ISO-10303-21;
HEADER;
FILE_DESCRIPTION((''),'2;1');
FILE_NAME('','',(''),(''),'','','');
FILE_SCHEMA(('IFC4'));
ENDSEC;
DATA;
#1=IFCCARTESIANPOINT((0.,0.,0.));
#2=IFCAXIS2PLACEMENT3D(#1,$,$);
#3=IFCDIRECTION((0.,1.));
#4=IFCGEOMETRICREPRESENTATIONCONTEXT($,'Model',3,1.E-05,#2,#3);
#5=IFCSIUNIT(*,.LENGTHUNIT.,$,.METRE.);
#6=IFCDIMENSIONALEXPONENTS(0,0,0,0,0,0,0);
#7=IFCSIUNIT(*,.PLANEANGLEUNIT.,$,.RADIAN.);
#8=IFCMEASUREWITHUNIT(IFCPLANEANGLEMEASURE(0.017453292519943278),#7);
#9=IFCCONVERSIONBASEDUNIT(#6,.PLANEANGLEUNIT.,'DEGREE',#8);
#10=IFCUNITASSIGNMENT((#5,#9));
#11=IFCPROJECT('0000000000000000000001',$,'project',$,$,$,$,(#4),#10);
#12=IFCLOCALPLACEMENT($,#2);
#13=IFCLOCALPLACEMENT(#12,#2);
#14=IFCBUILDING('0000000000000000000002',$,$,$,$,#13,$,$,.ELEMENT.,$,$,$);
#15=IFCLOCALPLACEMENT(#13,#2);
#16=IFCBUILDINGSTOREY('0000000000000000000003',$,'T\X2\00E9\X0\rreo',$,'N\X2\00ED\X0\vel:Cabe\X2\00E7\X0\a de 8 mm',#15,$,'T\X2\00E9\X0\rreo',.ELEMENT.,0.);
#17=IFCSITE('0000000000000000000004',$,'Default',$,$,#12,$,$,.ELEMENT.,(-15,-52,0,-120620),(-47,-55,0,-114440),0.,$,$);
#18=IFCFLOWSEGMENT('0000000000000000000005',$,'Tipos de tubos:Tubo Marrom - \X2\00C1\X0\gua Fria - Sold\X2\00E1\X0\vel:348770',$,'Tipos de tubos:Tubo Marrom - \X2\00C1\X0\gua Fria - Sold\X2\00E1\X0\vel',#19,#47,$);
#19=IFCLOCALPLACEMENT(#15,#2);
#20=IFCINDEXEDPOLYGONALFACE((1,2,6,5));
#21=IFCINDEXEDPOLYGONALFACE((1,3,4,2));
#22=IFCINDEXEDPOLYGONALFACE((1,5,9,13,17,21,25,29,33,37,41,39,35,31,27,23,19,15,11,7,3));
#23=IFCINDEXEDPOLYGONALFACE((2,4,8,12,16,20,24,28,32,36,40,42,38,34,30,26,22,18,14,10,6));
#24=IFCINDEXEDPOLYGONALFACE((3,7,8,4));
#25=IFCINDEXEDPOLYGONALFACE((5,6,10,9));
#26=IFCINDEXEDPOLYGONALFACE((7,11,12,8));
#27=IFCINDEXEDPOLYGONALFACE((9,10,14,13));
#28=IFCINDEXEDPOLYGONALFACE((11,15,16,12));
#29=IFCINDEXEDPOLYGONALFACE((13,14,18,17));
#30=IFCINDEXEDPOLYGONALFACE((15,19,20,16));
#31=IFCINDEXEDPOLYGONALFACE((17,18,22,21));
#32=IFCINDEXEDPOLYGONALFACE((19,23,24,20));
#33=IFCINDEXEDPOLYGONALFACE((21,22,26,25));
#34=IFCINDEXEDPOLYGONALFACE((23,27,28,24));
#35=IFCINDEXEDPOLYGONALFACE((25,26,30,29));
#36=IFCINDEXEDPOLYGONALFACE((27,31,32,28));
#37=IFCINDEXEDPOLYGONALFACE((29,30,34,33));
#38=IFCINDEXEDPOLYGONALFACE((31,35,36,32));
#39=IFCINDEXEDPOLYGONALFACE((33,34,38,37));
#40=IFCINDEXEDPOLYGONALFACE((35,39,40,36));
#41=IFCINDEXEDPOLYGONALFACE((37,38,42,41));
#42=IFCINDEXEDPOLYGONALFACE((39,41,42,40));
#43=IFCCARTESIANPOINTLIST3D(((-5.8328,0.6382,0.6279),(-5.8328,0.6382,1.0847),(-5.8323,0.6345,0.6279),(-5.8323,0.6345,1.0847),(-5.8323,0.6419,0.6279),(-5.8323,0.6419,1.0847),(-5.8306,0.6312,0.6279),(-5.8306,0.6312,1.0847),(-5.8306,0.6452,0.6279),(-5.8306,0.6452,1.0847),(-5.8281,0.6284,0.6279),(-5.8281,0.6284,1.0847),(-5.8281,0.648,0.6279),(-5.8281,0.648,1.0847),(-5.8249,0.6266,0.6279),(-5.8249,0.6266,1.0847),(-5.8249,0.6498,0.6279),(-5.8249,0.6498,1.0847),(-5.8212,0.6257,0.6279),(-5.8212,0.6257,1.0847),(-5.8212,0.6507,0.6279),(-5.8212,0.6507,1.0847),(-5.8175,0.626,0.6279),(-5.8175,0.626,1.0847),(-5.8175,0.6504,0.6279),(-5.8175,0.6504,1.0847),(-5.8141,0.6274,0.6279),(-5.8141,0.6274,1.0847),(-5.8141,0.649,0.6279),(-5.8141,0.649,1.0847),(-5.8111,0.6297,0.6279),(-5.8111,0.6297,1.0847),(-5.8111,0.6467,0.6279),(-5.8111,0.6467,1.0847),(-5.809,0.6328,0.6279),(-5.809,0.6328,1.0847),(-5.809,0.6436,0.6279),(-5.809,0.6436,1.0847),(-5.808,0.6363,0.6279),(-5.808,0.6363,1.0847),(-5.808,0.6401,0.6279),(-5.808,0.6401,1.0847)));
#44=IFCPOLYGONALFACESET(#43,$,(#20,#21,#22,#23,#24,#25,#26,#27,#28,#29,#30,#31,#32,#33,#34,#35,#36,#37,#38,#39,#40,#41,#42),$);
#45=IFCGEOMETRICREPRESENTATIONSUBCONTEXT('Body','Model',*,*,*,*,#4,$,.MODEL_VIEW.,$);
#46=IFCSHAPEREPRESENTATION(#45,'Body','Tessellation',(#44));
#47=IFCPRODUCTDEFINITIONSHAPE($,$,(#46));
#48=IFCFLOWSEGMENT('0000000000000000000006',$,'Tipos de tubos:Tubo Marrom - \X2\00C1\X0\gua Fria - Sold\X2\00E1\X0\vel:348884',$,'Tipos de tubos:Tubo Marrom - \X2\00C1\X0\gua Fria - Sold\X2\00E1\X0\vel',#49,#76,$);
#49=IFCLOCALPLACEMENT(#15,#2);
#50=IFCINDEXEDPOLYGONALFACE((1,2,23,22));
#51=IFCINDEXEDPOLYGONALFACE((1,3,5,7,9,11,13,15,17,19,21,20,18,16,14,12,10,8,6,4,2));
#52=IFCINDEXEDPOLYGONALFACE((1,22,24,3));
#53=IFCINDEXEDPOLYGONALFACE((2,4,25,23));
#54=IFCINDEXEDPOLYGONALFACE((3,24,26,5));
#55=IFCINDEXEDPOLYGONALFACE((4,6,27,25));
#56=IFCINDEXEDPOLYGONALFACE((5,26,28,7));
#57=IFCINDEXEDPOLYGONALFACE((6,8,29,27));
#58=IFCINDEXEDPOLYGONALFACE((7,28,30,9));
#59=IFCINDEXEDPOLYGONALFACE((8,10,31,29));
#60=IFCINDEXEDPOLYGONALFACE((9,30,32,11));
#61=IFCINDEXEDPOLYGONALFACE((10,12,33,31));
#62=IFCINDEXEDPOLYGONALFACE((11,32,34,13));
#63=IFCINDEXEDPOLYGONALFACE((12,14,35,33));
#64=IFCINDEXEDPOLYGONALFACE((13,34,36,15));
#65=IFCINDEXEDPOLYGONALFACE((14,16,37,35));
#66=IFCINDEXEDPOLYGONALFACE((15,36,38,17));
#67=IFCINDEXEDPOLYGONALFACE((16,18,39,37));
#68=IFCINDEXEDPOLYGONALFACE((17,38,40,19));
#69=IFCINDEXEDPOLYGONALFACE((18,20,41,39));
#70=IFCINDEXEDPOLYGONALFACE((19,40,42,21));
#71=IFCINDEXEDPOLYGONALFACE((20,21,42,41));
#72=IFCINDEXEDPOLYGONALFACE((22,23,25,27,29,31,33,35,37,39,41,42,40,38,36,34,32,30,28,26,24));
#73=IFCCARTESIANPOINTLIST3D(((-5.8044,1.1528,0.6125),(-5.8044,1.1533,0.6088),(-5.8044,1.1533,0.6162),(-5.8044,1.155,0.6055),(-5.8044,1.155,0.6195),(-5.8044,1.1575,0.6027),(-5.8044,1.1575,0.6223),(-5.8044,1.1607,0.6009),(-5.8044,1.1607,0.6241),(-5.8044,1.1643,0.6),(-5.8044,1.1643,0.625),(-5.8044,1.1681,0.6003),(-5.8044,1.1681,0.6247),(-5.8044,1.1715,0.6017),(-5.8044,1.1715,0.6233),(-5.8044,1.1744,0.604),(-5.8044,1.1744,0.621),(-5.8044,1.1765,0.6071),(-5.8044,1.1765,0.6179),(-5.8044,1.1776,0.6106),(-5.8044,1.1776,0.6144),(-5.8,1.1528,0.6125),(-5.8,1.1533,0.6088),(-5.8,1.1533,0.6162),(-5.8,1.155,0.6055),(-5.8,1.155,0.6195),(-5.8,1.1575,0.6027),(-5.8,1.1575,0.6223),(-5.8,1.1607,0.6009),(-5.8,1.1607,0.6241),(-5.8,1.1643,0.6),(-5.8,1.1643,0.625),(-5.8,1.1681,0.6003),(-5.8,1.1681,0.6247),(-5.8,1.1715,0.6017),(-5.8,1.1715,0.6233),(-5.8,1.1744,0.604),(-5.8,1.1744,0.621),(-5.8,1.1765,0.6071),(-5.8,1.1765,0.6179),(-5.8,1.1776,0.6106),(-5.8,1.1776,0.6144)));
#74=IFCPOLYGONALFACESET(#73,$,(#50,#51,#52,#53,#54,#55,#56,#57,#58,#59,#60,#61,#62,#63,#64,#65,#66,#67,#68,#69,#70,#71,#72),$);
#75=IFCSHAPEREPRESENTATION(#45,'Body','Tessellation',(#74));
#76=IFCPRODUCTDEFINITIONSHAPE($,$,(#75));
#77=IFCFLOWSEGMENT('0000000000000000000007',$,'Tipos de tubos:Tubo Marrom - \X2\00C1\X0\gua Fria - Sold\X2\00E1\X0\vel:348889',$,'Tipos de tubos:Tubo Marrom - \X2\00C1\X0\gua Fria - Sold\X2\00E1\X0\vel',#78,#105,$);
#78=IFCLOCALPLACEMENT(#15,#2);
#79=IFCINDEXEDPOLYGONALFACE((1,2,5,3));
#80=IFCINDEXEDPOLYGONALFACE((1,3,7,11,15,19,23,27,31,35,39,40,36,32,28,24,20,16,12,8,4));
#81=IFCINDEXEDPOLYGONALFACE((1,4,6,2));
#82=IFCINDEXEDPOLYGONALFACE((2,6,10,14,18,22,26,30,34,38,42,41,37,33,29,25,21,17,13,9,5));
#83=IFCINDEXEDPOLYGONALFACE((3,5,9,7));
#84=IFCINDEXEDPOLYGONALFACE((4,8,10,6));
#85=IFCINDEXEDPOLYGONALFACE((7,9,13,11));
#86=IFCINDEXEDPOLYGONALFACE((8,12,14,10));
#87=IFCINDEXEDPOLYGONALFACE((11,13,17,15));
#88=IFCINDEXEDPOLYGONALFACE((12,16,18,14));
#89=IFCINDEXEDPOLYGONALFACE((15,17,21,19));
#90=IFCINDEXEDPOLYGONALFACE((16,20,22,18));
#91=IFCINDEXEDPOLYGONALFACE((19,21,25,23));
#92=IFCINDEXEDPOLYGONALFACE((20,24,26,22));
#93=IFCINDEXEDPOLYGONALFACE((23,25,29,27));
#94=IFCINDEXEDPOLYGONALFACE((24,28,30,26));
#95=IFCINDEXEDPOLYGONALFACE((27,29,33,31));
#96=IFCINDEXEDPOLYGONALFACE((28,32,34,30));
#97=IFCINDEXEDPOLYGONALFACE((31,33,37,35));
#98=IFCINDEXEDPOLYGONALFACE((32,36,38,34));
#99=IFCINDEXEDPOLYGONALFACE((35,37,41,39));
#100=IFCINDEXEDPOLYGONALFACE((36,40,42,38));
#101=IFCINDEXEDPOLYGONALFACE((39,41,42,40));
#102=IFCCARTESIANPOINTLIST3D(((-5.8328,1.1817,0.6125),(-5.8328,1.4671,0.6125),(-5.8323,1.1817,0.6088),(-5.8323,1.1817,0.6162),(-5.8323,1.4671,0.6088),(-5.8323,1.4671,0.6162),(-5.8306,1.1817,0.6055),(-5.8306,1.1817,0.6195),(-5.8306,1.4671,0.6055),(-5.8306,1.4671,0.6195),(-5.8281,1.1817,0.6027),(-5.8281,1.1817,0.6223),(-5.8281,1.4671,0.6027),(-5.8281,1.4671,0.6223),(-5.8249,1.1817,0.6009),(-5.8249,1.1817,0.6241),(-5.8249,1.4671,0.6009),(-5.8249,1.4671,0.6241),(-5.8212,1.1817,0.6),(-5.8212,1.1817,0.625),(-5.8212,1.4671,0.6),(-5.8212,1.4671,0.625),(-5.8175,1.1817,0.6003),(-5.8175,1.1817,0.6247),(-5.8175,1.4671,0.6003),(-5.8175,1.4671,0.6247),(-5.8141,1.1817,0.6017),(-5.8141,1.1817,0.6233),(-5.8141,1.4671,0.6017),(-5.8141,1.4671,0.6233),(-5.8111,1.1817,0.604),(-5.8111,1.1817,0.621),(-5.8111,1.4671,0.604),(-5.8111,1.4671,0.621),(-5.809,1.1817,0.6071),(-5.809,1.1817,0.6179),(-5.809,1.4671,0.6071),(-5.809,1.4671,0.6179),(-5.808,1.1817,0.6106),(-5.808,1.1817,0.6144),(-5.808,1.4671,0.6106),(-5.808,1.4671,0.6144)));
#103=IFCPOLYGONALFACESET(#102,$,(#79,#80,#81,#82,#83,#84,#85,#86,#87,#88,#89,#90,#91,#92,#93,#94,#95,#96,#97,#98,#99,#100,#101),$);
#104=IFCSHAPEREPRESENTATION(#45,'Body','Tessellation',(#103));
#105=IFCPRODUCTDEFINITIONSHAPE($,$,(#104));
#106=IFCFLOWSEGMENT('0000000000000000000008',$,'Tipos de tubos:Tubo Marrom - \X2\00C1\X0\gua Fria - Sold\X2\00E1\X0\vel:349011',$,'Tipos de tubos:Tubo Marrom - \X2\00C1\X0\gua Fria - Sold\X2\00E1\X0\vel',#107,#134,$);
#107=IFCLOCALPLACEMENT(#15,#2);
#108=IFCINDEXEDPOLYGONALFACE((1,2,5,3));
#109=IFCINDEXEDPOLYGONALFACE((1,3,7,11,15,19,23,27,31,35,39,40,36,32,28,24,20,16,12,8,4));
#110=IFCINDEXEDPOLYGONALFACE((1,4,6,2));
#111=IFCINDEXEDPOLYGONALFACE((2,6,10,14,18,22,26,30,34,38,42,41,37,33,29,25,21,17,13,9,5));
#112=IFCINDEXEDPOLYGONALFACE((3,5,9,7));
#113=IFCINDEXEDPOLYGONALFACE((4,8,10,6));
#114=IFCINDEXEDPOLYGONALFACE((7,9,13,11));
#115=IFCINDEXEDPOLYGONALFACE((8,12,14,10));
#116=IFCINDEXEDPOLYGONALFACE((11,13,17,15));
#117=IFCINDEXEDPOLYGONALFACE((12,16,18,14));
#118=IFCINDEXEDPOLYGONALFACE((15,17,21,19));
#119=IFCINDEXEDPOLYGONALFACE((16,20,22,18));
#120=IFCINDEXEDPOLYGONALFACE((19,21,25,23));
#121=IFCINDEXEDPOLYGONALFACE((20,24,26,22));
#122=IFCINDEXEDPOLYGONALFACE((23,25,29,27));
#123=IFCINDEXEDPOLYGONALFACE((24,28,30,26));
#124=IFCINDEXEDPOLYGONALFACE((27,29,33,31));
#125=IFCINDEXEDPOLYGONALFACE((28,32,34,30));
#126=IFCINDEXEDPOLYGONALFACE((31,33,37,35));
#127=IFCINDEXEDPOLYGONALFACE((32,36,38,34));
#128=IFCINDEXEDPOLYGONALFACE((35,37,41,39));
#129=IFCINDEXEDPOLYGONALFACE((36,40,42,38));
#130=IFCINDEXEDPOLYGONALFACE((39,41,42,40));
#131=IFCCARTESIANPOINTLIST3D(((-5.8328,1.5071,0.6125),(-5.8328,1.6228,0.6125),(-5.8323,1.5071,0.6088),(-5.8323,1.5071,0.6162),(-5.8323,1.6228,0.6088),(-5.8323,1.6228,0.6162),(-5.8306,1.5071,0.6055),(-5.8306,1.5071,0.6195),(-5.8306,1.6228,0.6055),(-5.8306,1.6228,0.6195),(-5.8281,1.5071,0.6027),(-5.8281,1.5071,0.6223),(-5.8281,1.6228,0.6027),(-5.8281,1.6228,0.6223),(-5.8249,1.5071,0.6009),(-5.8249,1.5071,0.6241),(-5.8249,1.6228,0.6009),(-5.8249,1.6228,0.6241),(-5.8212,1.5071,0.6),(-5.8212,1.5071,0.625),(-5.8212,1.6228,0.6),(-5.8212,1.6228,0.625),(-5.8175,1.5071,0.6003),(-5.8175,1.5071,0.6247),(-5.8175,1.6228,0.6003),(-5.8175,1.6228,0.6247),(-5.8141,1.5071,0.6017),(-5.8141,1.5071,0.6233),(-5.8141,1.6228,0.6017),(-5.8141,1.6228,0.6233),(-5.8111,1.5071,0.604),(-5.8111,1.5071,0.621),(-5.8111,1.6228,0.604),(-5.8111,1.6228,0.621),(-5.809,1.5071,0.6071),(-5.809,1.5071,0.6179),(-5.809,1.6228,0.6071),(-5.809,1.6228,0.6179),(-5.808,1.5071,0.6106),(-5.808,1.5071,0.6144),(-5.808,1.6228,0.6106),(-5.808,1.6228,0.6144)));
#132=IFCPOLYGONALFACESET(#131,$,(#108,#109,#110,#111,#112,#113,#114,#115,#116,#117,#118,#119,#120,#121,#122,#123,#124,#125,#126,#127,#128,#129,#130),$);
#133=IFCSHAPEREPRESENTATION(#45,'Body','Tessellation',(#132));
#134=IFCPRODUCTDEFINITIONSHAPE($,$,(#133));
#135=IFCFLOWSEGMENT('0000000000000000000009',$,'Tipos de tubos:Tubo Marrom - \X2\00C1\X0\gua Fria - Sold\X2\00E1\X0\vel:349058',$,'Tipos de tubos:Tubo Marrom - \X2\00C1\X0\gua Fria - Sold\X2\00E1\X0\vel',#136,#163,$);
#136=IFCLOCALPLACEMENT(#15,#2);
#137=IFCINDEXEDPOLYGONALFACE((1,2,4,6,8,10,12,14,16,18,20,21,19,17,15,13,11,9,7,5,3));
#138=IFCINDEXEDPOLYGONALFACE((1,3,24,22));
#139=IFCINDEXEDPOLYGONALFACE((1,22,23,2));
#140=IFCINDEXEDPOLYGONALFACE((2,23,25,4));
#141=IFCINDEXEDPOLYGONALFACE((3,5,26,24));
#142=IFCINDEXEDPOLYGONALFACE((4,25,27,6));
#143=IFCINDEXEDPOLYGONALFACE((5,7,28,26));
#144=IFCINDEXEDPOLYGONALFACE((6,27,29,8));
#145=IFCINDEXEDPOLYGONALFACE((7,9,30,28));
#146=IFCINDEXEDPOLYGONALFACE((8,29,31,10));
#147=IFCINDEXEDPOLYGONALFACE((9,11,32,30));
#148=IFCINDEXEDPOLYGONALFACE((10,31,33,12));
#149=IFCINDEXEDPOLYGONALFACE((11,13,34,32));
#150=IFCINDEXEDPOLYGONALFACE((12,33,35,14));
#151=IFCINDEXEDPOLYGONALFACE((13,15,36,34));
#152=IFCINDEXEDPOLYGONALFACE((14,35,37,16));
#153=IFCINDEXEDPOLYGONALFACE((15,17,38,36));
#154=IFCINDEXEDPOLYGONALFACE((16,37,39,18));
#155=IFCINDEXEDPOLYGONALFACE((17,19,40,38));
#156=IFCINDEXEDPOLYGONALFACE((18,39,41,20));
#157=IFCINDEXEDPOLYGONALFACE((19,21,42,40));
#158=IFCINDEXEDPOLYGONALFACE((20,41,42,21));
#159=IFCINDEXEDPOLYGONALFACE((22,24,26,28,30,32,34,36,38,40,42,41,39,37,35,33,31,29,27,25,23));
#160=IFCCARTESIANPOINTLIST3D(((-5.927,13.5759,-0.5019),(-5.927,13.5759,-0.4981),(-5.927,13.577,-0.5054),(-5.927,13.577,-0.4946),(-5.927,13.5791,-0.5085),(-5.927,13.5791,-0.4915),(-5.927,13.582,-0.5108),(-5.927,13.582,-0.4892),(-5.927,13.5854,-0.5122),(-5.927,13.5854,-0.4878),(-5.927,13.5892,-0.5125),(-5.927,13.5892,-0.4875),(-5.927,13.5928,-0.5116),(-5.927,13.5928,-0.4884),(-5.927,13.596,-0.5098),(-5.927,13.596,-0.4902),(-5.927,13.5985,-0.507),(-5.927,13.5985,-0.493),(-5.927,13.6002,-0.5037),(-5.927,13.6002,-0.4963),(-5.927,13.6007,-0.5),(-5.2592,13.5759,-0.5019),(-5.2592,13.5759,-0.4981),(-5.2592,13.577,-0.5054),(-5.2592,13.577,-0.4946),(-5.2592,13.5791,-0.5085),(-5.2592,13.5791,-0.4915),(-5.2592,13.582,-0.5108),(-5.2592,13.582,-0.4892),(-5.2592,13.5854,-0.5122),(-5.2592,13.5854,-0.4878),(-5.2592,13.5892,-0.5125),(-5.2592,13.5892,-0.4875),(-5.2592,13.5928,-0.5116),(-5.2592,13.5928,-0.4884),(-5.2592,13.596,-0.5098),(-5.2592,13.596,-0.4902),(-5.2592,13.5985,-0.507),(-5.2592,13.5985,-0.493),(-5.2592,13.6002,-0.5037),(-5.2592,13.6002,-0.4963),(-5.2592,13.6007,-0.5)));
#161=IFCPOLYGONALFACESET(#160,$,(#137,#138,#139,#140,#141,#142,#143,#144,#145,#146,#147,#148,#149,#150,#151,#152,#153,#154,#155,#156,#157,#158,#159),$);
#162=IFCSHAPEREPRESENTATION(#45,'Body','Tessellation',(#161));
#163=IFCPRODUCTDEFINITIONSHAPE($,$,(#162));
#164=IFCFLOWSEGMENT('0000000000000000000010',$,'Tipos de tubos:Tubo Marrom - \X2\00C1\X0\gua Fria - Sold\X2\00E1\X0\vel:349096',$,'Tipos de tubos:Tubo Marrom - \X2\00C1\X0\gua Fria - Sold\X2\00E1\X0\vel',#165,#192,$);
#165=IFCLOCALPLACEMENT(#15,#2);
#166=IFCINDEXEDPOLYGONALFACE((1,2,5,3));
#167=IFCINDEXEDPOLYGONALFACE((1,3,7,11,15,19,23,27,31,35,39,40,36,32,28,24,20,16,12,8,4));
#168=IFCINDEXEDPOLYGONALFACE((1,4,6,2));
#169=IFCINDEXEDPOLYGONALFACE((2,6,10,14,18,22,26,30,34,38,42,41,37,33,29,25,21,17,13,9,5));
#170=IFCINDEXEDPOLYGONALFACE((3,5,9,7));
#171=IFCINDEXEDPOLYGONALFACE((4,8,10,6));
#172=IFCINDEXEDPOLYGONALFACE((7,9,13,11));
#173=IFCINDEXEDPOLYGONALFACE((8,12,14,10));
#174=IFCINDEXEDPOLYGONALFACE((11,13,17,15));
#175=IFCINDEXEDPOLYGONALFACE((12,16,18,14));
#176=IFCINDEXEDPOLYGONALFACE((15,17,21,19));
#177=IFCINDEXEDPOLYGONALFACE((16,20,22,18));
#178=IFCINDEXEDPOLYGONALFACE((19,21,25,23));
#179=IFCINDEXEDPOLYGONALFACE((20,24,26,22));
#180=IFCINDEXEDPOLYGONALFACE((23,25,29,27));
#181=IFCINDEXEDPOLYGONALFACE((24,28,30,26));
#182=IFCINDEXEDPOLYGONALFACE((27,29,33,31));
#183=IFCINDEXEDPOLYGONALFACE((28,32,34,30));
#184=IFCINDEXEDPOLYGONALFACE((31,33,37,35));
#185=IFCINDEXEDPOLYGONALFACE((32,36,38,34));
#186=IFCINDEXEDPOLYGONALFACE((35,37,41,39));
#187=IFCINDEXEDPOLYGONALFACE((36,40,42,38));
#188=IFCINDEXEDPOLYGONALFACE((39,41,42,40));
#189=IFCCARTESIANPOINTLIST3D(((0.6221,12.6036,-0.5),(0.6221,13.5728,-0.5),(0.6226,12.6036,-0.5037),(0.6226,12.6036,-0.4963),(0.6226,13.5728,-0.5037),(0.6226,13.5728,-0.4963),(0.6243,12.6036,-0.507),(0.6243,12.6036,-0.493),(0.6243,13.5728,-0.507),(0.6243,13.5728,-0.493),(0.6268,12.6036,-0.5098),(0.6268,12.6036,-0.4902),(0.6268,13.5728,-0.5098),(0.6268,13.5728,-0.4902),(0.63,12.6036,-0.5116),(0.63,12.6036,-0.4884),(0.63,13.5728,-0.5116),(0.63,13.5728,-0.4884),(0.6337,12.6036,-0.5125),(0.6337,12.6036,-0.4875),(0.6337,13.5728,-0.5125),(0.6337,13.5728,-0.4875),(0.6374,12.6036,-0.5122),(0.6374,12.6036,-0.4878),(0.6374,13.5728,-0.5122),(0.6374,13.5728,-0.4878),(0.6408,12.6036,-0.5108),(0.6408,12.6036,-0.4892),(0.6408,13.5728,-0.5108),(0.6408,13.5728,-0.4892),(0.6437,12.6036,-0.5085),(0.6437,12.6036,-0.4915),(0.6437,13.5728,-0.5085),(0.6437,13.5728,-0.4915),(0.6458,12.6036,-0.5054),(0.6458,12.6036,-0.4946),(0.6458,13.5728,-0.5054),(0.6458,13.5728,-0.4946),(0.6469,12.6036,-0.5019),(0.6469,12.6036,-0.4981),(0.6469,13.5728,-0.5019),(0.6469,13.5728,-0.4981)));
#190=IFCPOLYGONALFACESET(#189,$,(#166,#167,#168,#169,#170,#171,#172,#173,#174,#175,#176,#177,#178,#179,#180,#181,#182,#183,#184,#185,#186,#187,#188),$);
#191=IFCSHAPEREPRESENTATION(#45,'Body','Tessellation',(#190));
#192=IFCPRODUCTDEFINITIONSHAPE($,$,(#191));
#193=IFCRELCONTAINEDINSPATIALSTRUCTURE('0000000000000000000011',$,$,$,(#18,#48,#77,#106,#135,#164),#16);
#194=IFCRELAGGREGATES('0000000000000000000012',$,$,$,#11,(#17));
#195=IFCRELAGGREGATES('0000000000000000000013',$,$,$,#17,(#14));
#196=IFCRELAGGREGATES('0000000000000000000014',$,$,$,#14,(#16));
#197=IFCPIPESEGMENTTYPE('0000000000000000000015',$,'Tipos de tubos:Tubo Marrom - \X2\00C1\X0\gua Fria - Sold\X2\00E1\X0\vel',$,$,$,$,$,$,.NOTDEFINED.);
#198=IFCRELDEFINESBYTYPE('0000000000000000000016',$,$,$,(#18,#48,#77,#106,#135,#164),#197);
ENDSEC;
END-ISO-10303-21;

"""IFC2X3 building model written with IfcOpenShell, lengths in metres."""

from ifc_helpers import new_model, entity, si_unit, converted_unit, direction, frame, frame_2d, origin, origin_2d_with_axis, place, context, subcontext, project, spatial, circle, extrude, type_object, element, save


model = new_model("IFC2X3")

# Units and contexts
model_context = context("Model", 3, precision=1e-05, world=origin(), true_north=direction((0.0, 1.0)))
body_context = subcontext(model_context, "Body", "Model", "MODEL_VIEW")
ifc_project = project(units=[si_unit("LENGTHUNIT", "METRE"), converted_unit("PLANEANGLEUNIT", "DEGREE", entity("IfcPlaneAngleMeasure", 0.017453292519943278), si_unit("PLANEANGLEUNIT", "RADIAN"), dimensions=[0, 0, 0, 0, 0, 0, 0])], contexts=[model_context])

# Site, building, storey
site_placement = place(None, origin())
site = spatial("IfcSite", under=ifc_project, at=site_placement, Name="Default", CompositionType="ELEMENT", RefLatitude=(-15, -52, 0, -120620), RefLongitude=(-47, -55, 0, -114440), RefElevation=0.0)
building_placement = place(site_placement, origin())
building = spatial("IfcBuilding", under=site, at=building_placement, CompositionType="ELEMENT")
storey_placement = place(building_placement, origin())
storey = spatial("IfcBuildingStorey", under=building, at=storey_placement, Name="Térreo", ObjectType="Nível:Cabeça de 8 mm", LongName="Térreo", CompositionType="ELEMENT", Elevation=0.0)

# Flow segments
pipe_segment_type = type_object("IfcPipeSegmentType", Name="Tipos de tubos:Tubo Marrom - Água Fria - Soldável", PredefinedType="NOTDEFINED")
flow_segment_1_placement = place(storey_placement, origin())
element("IfcFlowSegment", 1, at=flow_segment_1_placement, inside=storey, type_object=pipe_segment_type, Name="Tipos de tubos:Tubo Marrom - Água Fria - Soldável:348770", ObjectType="Tipos de tubos:Tubo Marrom - Água Fria - Soldável", context=body_context, shape_type="SweptSolid", body=[
    extrude(circle(Radius=0.0125, at=frame_2d((0.0, 0.0), x_axis=(1.0, 0.0))), frame((-5.8203, 0.6382, 0.6279), z_axis=(0.0, 0.0, 1.0), x_axis=(-1.0, 0.0, 0.0)), (0.0, 0.0, 1.0), 0.4568),
])
flow_segment_2_placement = place(storey_placement, origin())
element("IfcFlowSegment", 2, at=flow_segment_2_placement, inside=storey, type_object=pipe_segment_type, Name="Tipos de tubos:Tubo Marrom - Água Fria - Soldável:348884", ObjectType="Tipos de tubos:Tubo Marrom - Água Fria - Soldável", context=body_context, shape_type="SweptSolid", body=[
    extrude(circle(Radius=0.0125, at=origin_2d_with_axis()), frame((-5.8044, 1.1653, 0.6125), z_axis=(1.0, 0.0, 0.0), x_axis=(0.0, -1.0, 0.0)), (0.0, 0.0, 1.0), 0.0044),
])
flow_segment_3_placement = place(storey_placement, origin())
element("IfcFlowSegment", 3, at=flow_segment_3_placement, inside=storey, type_object=pipe_segment_type, Name="Tipos de tubos:Tubo Marrom - Água Fria - Soldável:348889", ObjectType="Tipos de tubos:Tubo Marrom - Água Fria - Soldável", context=body_context, shape_type="SweptSolid", body=[
    extrude(circle(Radius=0.0125, at=origin_2d_with_axis()), frame((-5.8203, 1.1817, 0.6125), z_axis=(0.0, 1.0, 0.0), x_axis=(-1.0, 0.0, 0.0)), (0.0, 0.0, 1.0), 0.2855),
])
flow_segment_4_placement = place(storey_placement, origin())
element("IfcFlowSegment", 4, at=flow_segment_4_placement, inside=storey, type_object=pipe_segment_type, Name="Tipos de tubos:Tubo Marrom - Água Fria - Soldável:349011", ObjectType="Tipos de tubos:Tubo Marrom - Água Fria - Soldável", context=body_context, shape_type="SweptSolid", body=[
    extrude(circle(Radius=0.0125, at=origin_2d_with_axis()), frame((-5.8203, 1.5071, 0.6125), z_axis=(0.0, 1.0, 0.0), x_axis=(-1.0, 0.0, 0.0)), (0.0, 0.0, 1.0), 0.1157),
])
flow_segment_5_placement = place(storey_placement, origin())
element("IfcFlowSegment", 5, at=flow_segment_5_placement, inside=storey, type_object=pipe_segment_type, Name="Tipos de tubos:Tubo Marrom - Água Fria - Soldável:349058", ObjectType="Tipos de tubos:Tubo Marrom - Água Fria - Soldável", context=body_context, shape_type="SweptSolid", body=[
    extrude(circle(Radius=0.0125, at=frame_2d((0.0, 0.0), x_axis=(1.0, 0.0))), frame((-5.927, 13.5882, -0.5), z_axis=(1.0, 0.0, 0.0), x_axis=(0.0, 1.0, 0.0)), (0.0, 0.0, 1.0), 0.6679),
])
flow_segment_6_placement = place(storey_placement, origin())
element("IfcFlowSegment", 6, at=flow_segment_6_placement, inside=storey, type_object=pipe_segment_type, Name="Tipos de tubos:Tubo Marrom - Água Fria - Soldável:349096", ObjectType="Tipos de tubos:Tubo Marrom - Água Fria - Soldável", context=body_context, shape_type="SweptSolid", body=[
    extrude(circle(Radius=0.0125, at=frame_2d((0.0, 0.0), x_axis=(1.0, 0.0))), frame((0.6346, 12.6036, -0.5), z_axis=(0.0, 1.0, 0.0), x_axis=(-1.0, 0.0, 0.0)), (0.0, 0.0, 1.0), 0.9692),
])

save(model, "model.ifc")
